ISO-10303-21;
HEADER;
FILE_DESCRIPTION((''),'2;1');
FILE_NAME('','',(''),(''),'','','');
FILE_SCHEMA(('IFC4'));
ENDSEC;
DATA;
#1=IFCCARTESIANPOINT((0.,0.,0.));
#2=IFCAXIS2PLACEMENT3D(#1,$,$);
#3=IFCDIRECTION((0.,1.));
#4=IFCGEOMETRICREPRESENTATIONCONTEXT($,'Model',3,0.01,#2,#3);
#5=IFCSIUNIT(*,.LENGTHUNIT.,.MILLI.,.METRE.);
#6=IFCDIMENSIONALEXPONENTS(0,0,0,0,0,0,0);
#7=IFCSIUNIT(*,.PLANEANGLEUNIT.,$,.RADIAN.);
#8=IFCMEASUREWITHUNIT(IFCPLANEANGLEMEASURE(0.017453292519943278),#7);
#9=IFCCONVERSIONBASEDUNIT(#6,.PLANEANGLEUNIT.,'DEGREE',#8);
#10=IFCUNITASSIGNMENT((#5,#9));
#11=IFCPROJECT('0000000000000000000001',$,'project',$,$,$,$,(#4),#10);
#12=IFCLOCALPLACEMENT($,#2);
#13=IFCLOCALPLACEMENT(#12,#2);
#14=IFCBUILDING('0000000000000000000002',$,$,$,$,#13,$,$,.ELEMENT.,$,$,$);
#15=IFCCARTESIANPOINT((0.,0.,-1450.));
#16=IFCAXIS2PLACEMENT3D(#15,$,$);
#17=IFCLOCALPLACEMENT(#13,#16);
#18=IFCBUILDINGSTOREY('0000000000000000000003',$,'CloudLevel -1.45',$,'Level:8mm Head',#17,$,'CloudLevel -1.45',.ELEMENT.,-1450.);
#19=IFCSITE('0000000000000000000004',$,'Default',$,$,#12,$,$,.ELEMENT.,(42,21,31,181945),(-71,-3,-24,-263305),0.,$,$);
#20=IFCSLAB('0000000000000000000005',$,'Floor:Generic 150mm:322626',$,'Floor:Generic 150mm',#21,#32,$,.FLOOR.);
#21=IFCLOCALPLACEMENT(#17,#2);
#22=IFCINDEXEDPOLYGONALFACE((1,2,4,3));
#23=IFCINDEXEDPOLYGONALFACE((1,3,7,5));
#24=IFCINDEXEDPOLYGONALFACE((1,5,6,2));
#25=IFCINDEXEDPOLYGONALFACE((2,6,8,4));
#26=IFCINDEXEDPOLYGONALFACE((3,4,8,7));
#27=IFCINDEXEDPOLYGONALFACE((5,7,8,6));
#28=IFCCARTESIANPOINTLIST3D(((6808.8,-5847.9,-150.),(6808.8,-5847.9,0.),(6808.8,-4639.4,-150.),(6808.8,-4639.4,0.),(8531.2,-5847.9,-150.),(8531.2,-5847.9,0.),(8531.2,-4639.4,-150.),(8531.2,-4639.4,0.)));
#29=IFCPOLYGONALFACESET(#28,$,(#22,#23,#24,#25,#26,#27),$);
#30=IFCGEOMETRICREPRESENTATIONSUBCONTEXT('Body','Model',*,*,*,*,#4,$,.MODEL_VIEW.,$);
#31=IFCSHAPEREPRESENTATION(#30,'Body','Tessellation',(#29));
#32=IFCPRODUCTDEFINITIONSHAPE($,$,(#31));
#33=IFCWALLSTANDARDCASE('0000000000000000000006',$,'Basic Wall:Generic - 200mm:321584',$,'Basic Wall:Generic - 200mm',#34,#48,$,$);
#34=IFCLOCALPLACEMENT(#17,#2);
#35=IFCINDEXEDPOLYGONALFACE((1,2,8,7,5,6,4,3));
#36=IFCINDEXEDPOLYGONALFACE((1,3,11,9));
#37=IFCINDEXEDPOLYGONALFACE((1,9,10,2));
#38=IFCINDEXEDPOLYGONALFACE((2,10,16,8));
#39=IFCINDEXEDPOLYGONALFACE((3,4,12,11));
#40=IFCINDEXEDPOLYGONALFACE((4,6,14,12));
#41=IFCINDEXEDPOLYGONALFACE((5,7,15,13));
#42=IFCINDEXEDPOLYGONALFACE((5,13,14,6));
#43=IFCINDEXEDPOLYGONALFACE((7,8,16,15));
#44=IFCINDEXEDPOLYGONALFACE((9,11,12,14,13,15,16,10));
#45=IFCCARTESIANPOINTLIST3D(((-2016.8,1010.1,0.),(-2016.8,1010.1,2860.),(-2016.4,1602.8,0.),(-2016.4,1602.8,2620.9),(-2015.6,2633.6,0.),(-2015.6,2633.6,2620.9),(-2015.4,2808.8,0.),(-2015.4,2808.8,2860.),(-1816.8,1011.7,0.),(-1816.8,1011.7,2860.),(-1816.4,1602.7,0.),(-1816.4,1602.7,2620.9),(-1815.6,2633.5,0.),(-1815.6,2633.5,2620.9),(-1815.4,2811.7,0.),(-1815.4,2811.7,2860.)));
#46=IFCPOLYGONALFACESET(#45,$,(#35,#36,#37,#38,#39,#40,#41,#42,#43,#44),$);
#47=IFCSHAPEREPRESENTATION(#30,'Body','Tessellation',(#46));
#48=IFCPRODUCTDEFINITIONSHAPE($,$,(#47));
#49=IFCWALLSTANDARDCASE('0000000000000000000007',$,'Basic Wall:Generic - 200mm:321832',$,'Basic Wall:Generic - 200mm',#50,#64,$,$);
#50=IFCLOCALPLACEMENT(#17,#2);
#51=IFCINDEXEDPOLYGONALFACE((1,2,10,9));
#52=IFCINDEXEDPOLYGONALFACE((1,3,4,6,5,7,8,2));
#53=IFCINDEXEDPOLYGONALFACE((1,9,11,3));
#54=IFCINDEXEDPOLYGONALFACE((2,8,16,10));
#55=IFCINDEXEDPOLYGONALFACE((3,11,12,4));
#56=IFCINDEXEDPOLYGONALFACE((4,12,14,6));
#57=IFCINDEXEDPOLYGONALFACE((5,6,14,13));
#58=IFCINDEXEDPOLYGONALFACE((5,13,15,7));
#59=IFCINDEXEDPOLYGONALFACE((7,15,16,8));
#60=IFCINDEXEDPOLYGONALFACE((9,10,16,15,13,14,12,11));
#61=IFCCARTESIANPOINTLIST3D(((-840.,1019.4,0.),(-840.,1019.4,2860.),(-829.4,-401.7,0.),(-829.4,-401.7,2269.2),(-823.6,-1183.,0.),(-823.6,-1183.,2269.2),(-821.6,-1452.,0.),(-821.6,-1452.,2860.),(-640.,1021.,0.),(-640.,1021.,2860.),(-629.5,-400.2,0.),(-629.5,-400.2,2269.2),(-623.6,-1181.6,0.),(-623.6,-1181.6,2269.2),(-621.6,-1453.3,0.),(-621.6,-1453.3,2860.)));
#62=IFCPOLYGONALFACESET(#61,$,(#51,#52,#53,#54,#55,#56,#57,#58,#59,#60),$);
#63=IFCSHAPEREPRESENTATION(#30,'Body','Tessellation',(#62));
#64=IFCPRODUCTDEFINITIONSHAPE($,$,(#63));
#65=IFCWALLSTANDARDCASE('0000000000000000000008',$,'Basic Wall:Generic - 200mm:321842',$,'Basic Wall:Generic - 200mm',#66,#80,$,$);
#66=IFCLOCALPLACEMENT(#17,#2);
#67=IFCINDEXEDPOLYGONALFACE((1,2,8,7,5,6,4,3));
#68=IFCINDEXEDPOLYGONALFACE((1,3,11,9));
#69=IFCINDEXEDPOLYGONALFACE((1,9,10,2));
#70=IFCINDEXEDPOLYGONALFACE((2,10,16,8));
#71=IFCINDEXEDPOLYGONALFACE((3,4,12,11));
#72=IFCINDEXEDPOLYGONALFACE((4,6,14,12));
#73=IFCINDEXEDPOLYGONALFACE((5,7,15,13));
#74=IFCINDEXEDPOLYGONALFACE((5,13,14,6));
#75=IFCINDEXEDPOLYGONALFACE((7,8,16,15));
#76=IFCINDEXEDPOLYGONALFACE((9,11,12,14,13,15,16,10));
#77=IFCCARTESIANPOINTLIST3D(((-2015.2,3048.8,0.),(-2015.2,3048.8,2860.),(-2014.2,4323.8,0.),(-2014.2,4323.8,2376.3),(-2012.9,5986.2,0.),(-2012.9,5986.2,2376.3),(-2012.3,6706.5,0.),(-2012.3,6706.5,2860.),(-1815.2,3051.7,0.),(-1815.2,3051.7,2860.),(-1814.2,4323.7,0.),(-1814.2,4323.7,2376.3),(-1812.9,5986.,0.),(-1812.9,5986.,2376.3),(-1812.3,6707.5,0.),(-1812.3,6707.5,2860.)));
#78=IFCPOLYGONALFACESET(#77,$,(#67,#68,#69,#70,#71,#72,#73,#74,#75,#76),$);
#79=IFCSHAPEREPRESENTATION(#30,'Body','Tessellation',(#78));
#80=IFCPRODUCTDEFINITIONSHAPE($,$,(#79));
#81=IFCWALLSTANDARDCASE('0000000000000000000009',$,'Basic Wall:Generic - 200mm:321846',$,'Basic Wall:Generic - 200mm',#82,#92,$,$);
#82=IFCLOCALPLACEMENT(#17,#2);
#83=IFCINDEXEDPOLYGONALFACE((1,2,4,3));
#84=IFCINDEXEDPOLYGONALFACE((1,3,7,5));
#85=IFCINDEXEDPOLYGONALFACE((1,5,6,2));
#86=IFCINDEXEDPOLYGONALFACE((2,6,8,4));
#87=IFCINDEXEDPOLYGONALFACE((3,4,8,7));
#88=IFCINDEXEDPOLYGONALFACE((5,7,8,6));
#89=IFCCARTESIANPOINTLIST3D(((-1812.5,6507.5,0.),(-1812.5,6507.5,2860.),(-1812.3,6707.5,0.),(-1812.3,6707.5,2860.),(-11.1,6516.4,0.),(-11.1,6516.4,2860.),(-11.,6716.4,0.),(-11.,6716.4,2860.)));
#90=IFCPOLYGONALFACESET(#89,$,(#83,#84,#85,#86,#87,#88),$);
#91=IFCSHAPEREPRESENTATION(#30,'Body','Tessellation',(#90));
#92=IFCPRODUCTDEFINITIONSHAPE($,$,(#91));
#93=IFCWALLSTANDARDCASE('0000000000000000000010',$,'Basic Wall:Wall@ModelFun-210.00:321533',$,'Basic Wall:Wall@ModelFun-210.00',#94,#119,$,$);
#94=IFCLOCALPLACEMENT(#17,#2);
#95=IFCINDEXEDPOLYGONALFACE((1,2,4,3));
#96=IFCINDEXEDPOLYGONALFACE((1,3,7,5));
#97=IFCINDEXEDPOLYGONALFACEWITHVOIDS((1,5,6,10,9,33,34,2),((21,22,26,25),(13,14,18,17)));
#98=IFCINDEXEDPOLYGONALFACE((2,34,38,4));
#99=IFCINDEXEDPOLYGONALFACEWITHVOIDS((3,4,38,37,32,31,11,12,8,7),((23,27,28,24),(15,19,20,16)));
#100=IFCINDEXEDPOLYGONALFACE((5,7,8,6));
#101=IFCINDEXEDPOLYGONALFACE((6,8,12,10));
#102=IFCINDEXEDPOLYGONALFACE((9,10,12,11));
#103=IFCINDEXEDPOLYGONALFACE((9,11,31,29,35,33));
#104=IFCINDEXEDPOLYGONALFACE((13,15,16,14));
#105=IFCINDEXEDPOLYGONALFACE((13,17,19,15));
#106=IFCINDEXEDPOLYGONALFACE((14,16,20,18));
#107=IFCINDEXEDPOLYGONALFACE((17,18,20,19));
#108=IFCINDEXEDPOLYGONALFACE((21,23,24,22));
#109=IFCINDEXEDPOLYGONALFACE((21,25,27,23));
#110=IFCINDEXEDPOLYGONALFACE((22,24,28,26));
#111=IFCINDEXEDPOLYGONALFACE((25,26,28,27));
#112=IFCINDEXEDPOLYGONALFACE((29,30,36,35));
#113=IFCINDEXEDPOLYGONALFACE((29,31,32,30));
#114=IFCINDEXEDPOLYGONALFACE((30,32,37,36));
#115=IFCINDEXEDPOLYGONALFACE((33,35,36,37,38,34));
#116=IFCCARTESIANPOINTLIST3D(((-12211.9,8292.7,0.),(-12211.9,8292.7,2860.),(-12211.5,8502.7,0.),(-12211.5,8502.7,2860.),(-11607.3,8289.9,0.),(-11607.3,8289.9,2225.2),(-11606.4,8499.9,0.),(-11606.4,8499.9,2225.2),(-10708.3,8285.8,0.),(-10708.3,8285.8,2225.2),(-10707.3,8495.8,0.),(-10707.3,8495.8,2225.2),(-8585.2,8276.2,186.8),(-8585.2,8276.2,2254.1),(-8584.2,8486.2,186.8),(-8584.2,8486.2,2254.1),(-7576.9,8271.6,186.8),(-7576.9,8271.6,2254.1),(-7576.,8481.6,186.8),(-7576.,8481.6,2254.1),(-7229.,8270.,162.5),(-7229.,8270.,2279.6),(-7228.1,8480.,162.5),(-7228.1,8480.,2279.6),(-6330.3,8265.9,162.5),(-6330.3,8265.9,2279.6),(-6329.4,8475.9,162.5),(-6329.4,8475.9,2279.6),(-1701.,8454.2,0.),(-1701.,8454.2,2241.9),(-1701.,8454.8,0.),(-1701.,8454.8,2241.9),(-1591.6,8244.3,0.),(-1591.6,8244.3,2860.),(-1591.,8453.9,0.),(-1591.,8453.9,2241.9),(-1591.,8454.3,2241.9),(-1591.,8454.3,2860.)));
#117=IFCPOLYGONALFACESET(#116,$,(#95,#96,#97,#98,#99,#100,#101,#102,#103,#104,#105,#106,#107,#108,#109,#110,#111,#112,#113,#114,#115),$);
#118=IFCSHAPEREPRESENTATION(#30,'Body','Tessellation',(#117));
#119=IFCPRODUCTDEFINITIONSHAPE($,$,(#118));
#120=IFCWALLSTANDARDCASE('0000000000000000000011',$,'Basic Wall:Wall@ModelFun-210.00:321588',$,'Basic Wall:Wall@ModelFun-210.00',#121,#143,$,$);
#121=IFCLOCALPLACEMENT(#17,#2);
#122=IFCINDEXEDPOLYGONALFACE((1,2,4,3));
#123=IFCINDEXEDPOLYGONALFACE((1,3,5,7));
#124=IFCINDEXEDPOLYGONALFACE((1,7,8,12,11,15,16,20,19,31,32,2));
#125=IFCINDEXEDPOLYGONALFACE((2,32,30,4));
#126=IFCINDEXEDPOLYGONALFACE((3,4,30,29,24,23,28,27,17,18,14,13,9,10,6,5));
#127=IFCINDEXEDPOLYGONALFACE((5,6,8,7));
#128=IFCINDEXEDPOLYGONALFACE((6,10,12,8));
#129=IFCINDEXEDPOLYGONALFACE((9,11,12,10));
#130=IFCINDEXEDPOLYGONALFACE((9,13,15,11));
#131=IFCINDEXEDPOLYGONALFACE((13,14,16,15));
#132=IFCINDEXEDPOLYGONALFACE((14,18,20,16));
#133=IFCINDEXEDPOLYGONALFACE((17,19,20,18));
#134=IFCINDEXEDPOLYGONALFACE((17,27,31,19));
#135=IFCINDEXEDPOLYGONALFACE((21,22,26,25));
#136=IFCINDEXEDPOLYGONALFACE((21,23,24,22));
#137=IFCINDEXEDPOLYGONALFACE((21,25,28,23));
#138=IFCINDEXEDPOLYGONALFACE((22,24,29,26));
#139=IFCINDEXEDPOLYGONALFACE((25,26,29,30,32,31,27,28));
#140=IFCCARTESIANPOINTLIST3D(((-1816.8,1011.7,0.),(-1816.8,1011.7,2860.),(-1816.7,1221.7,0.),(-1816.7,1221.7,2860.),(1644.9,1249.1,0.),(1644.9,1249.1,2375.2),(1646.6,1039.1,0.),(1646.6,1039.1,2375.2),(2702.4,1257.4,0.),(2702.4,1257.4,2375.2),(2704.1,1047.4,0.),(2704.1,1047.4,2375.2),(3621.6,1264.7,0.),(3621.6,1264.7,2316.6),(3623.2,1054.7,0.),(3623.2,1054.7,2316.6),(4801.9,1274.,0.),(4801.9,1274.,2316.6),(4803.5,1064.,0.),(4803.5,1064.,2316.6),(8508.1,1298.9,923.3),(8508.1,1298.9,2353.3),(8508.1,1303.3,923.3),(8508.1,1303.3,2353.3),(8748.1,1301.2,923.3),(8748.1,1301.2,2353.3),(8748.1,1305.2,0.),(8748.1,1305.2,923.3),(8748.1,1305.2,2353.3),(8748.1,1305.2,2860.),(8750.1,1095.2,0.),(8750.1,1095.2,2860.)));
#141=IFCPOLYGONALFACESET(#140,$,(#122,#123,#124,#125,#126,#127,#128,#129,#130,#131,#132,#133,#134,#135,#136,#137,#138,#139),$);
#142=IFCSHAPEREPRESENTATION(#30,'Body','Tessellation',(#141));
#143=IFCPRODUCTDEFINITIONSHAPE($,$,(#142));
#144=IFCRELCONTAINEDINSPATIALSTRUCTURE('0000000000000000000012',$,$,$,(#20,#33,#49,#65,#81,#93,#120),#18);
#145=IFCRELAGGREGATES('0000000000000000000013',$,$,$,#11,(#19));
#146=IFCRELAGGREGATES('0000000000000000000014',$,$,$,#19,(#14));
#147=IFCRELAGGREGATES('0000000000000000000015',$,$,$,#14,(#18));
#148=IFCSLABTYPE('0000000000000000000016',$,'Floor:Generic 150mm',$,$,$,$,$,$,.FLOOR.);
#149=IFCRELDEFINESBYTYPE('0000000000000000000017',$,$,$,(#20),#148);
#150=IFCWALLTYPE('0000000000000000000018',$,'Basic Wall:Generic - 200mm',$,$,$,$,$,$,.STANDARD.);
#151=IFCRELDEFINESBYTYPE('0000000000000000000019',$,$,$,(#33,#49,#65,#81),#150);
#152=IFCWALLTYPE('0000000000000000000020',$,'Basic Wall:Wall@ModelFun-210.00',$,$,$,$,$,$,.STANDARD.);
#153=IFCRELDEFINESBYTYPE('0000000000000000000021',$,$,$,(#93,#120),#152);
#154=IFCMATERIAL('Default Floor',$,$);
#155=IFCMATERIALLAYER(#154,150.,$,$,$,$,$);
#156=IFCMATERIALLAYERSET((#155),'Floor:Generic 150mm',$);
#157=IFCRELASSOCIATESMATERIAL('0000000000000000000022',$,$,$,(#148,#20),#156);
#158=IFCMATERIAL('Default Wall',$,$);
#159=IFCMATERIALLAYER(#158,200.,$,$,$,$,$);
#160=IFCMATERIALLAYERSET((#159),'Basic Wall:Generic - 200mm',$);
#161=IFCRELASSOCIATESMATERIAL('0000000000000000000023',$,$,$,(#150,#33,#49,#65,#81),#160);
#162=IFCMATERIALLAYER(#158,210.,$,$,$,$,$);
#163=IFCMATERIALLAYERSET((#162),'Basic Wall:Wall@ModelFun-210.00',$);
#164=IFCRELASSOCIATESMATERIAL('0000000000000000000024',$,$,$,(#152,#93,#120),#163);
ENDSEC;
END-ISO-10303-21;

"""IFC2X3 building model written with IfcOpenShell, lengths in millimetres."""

from ifc_helpers import new_model, entity, si_unit, converted_unit, direction, frame, frame_2d, origin, origin_2d_with_axis, place, context, subcontext, project, spatial, polyline, rectangle, outline, extrude, material, layer, layer_set, layer_usage, type_object, element, save


model = new_model("IFC2X3")

# Units and contexts
model_context = context("Model", 3, precision=0.01, world=origin(), true_north=direction((0.0, 1.0)))
body_context = subcontext(model_context, "Body", "Model", "MODEL_VIEW")
ifc_project = project(units=[si_unit("LENGTHUNIT", "METRE", prefix="MILLI"), converted_unit("PLANEANGLEUNIT", "DEGREE", entity("IfcPlaneAngleMeasure", 0.017453292519943278), si_unit("PLANEANGLEUNIT", "RADIAN"), dimensions=[0, 0, 0, 0, 0, 0, 0])], contexts=[model_context])

# Site, building, storey
site_placement = place(None, origin())
site = spatial("IfcSite", under=ifc_project, at=site_placement, Name="Default", CompositionType="ELEMENT", RefLatitude=(42, 21, 31, 181945), RefLongitude=(-71, -3, -24, -263305), RefElevation=0.0)
building_placement = place(site_placement, origin())
building = spatial("IfcBuilding", under=site, at=building_placement, CompositionType="ELEMENT")
storey_placement = place(building_placement, frame((0.0, 0.0, -1450.0)))
storey = spatial("IfcBuildingStorey", under=building, at=storey_placement, Name="CloudLevel -1.45", ObjectType="Level:8mm Head", LongName="CloudLevel -1.45", CompositionType="ELEMENT", Elevation=-1450.0)

# Slab
ifc_material_1 = material(Name="Default Floor")
ifc_layer_1 = layer(ifc_material_1, 150.0)
ifc_layer_set_1 = layer_set([ifc_layer_1], Name="Floor:Generic 150mm")
ifc_layer_usage_1 = layer_usage(ifc_layer_set_1, "AXIS3", "POSITIVE", 0.0)
slab_type = type_object("IfcSlabType", Name="Floor:Generic 150mm", PredefinedType="FLOOR", material=ifc_layer_set_1)
slab_1_placement = place(storey_placement, origin())
element("IfcSlab", 1, at=slab_1_placement, inside=storey, type_object=slab_type, material=ifc_layer_usage_1, Name="Floor:Generic 150mm:322626", ObjectType="Floor:Generic 150mm", PredefinedType="FLOOR", context=body_context, shape_type="SweptSolid", body=[
    extrude(rectangle(XDim=1208.4, YDim=1722.4, at=origin_2d_with_axis()), frame((7670.0, -5243.6, 0.0), z_axis=(0.0, 0.0, -1.0), x_axis=(0.0, 1.0, 0.0)), (0.0, 0.0, 1.0), 150.0),
])

# Walls, openings
ifc_material_2 = material(Name="Default Wall")
ifc_layer_2 = layer(ifc_material_2, 200.0)
ifc_layer_set_2 = layer_set([ifc_layer_2], Name="Basic Wall:Generic - 200mm")
ifc_layer_usage_2 = layer_usage(ifc_layer_set_2, "AXIS2", "NEGATIVE", 100.0)
wall_type_1 = type_object("IfcWallType", Name="Basic Wall:Generic - 200mm", PredefinedType="STANDARD", material=ifc_layer_set_2)
wall_1_placement = place(storey_placement, frame((-1916.8, 1010.0, 0.0), z_axis=(0.0, 0.0, 1.0), x_axis=(0.000789, 1.0, 0.0)))
wall_1 = element("IfcWallStandardCase", 2, at=wall_1_placement, inside=storey, type_object=wall_type_1, material=ifc_layer_usage_2, Name="Basic Wall:Generic - 200mm:321584", ObjectType="Basic Wall:Generic - 200mm", context=body_context, shape_type="SweptSolid", body=[
    extrude(outline(polyline([(1.7, -100.0), (211.7, -100.0), (1801.7, -100.0), (1798.7, 100.0), (159.3, 100.0), (0.0, 100.0), (1.6, -81.1), (1.7, -100.0)])), origin(), (0.0, 0.0, 1.0), 2860.0),
])
opening_1_placement = place(wall_1_placement, frame((592.7, -100.0, 0.0)))
element("IfcOpeningElement", 3, at=opening_1_placement, cuts=wall_1, ObjectType="Opening", context=body_context, shape_type="SweptSolid", body=[
    extrude(rectangle(XDim=1030.8, YDim=2620.9, at=frame_2d((1310.5, 515.4), x_axis=(0.0, 1.0))), frame((0.0, 0.0, 0.0), z_axis=(0.0, 1.0, 0.0), x_axis=(0.0, 0.0, 1.0)), (0.0, 0.0, 1.0), 200.0),
])
wall_2_placement = place(storey_placement, frame((-740.0, 1020.2, 0.0), z_axis=(0.0, 0.0, 1.0), x_axis=(0.007442, -0.999972, 0.0)))
wall_2 = element("IfcWallStandardCase", 4, at=wall_2_placement, inside=storey, type_object=wall_type_1, material=ifc_layer_usage_2, Name="Basic Wall:Generic - 200mm:321832", ObjectType="Basic Wall:Generic - 200mm", context=body_context, shape_type="SweptSolid", body=[
    extrude(outline(polyline([(0.1, -100.0), (2471.6, -100.0), (2474.3, 100.0), (0.0, 100.0), (0.1, -100.0)])), origin(), (0.0, 0.0, 1.0), 2860.0),
])
opening_2_placement = place(wall_2_placement, frame((1421.2, -100.0, 0.0)))
element("IfcOpeningElement", 5, at=opening_2_placement, cuts=wall_2, ObjectType="Opening", context=body_context, shape_type="SweptSolid", body=[
    extrude(rectangle(XDim=781.4, YDim=2269.2, at=frame_2d((1134.6, 390.7), x_axis=(0.0, 1.0))), frame((0.0, 0.0, 0.0), z_axis=(0.0, 1.0, 0.0), x_axis=(0.0, 0.0, 1.0)), (0.0, 0.0, 1.0), 200.0),
])
wall_3_placement = place(storey_placement, frame((-1912.3, 6707.5, 0.0), z_axis=(0.0, 0.0, 1.0), x_axis=(-0.000789, -1.0, 0.0)))
wall_3 = element("IfcWallStandardCase", 6, at=wall_3_placement, inside=storey, type_object=wall_type_1, material=ifc_layer_usage_2, Name="Basic Wall:Generic - 200mm:321842", ObjectType="Basic Wall:Generic - 200mm", context=body_context, shape_type="SweptSolid", body=[
    extrude(outline(polyline([(1.2, -100.0), (2995.4, -100.0), (3335.4, -100.0), (3658.8, -100.0), (3655.7, 100.0), (200.0, 100.0), (0.0, 100.0), (1.2, -100.0)])), origin(), (0.0, 0.0, 1.0), 2860.0),
])
opening_3_placement = place(wall_3_placement, frame((721.4, -100.0, 0.0)))
element("IfcOpeningElement", 7, at=opening_3_placement, cuts=wall_3, ObjectType="Opening", context=body_context, shape_type="SweptSolid", body=[
    extrude(rectangle(XDim=1662.3, YDim=2376.3, at=frame_2d((1188.1, 831.2), x_axis=(0.0, 1.0))), frame((0.0, 0.0, 0.0), z_axis=(0.0, 1.0, 0.0), x_axis=(0.0, 0.0, 1.0)), (0.0, 0.0, 1.0), 200.0),
])

# Wall
wall_4_placement = place(storey_placement, frame((-10.5, 6616.4, 0.0), z_axis=(0.0, 0.0, 1.0), x_axis=(-0.999988, -0.004967, 0.0)))
element("IfcWallStandardCase", 8, at=wall_4_placement, inside=storey, type_object=wall_type_1, material=ifc_layer_usage_2, Name="Basic Wall:Generic - 200mm:321846", ObjectType="Basic Wall:Generic - 200mm", context=body_context, shape_type="SweptSolid", body=[
    extrude(outline(polyline([(1801.3, -100.0), (1802.5, 100.0), (1.0, 100.0), (0.0, -100.0), (1801.3, -100.0)])), origin(), (0.0, 0.0, 1.0), 2860.0),
])

# Walls, openings
ifc_layer_3 = layer(ifc_material_2, 210.0)
ifc_layer_set_3 = layer_set([ifc_layer_3], Name="Basic Wall:Wall@ModelFun-210.00")
ifc_layer_usage_3 = layer_usage(ifc_layer_set_3, "AXIS2", "NEGATIVE", 105.0)
wall_type_2 = type_object("IfcWallType", Name="Basic Wall:Wall@ModelFun-210.00", PredefinedType="STANDARD", material=ifc_layer_set_3)
wall_5_placement = place(storey_placement, frame((-1591.1, 8349.3, 0.0), z_axis=(0.0, 0.0, 1.0), x_axis=(-0.99999, 0.004552, 0.0)))
wall_5 = element("IfcWallStandardCase", 9, at=wall_5_placement, inside=storey, type_object=wall_type_2, material=ifc_layer_usage_3, Name="Basic Wall:Wall@ModelFun-210.00:321533", ObjectType="Basic Wall:Wall@ModelFun-210.00", context=body_context, shape_type="SweptSolid", body=[
    extrude(outline(polyline([(0.3, -105.0), (110.3, -105.0), (2714.6, -105.0), (2914.6, -105.0), (5712.3, -105.0), (5922.3, -105.0), (10621.0, -105.0), (10620.4, 105.0), (7415.2, 105.0), (7215.2, 105.0), (42.9, 105.0), (0.0, 105.0), (0.2, -3.9), (0.3, -105.0)])), origin(), (0.0, 0.0, 1.0), 2860.0),
])
opening_4_placement = place(wall_5_placement, origin())
element("IfcOpeningElement", 10, at=opening_4_placement, cuts=wall_5, ObjectType="Opening", context=body_context, shape_type="SweptSolid", body=[
    extrude(rectangle(XDim=2241.9, YDim=110.0, at=frame_2d((0.0, 0.0), x_axis=(0.0, 1.0))), frame((56.8, -1102.6, 1121.0), z_axis=(-0.00152, 0.999999, 0.0), x_axis=(-0.999999, -0.00152, 0.0)), (0.0, 0.0, 1.0), 998.2),
])
opening_5_placement = place(wall_5_placement, frame((9116.8, -105.0, 0.0)))
element("IfcOpeningElement", 11, at=opening_5_placement, cuts=wall_5, ObjectType="Opening", context=body_context, shape_type="SweptSolid", body=[
    extrude(rectangle(XDim=899.1, YDim=2225.2, at=frame_2d((1112.6, 449.5), x_axis=(0.0, 1.0))), frame((0.0, 0.0, 0.0), z_axis=(0.0, 1.0, 0.0), x_axis=(0.0, 0.0, 1.0)), (0.0, 0.0, 1.0), 210.0),
])
opening_6_placement = place(wall_5_placement, frame((5985.4, -105.0, 186.8)))
element("IfcOpeningElement", 12, at=opening_6_placement, cuts=wall_5, ObjectType="Opening", context=body_context, shape_type="SweptSolid", body=[
    extrude(rectangle(XDim=1008.3, YDim=2067.2, at=frame_2d((1033.6, 504.1), x_axis=(0.0, 1.0))), frame((0.0, 0.0, 0.0), z_axis=(0.0, 1.0, 0.0), x_axis=(0.0, 0.0, 1.0)), (0.0, 0.0, 1.0), 210.0),
])
opening_7_placement = place(wall_5_placement, frame((4738.8, -105.0, 162.5)))
element("IfcOpeningElement", 13, at=opening_7_placement, cuts=wall_5, ObjectType="Opening", context=body_context, shape_type="SweptSolid", body=[
    extrude(rectangle(XDim=898.7, YDim=2117.2, at=frame_2d((1058.6, 449.3), x_axis=(0.0, 1.0))), frame((0.0, 0.0, 0.0), z_axis=(0.0, 1.0, 0.0), x_axis=(0.0, 0.0, 1.0)), (0.0, 0.0, 1.0), 210.0),
])
wall_6_placement = place(storey_placement, frame((-1817.7, 1116.7, 0.0), z_axis=(0.0, 0.0, 1.0), x_axis=(0.999969, 0.007904, 0.0)))
wall_6 = element("IfcWallStandardCase", 14, at=wall_6_placement, inside=storey, type_object=wall_type_2, material=ifc_layer_usage_3, Name="Basic Wall:Wall@ModelFun-210.00:321588", ObjectType="Basic Wall:Wall@ModelFun-210.00", context=body_context, shape_type="SweptSolid", body=[
    extrude(outline(polyline([(0.0, -105.0), (976.8, -105.0), (1176.8, -105.0), (3237.3, -105.0), (3417.3, -105.0), (4936.9, -105.0), (5146.9, -105.0), (6719.8, -105.0), (6959.8, -105.0), (8889.3, -105.0), (9099.3, -105.0), (10088.5, -105.0), (10328.5, -105.0), (10567.3, -105.0), (10566.9, 105.0), (10326.9, 105.0), (2047.3, 105.0), (1807.3, 105.0), (1.8, 105.0), (0.0, -105.0)])), origin(), (0.0, 0.0, 1.0), 2860.0),
])
opening_8_placement = place(wall_6_placement, origin())
element("IfcOpeningElement", 15, at=opening_8_placement, cuts=wall_6, ObjectType="Opening", context=body_context, shape_type="SweptSolid", body=[
    extrude(rectangle(XDim=1430.0, YDim=240.0, at=frame_2d((0.0, 0.0), x_axis=(0.0, 1.0))), frame((10446.9, 100.8, 1638.3), z_axis=(-0.001607, 0.999999, 0.0), x_axis=(-0.999999, -0.001607, 0.0)), (0.0, 0.0, 1.0), 510.0),
])
opening_9_placement = place(wall_6_placement, frame((5440.2, -105.0, 0.0)))
element("IfcOpeningElement", 16, at=opening_9_placement, cuts=wall_6, ObjectType="Opening", context=body_context, shape_type="SweptSolid", body=[
    extrude(rectangle(XDim=1180.4, YDim=2316.6, at=frame_2d((1158.3, 590.2), x_axis=(0.0, 1.0))), frame((0.0, 0.0, 0.0), z_axis=(0.0, 1.0, 0.0), x_axis=(0.0, 0.0, 1.0)), (0.0, 0.0, 1.0), 210.0),
])
opening_10_placement = place(wall_6_placement, frame((3463.5, -105.0, 0.0)))
element("IfcOpeningElement", 17, at=opening_10_placement, cuts=wall_6, ObjectType="Opening", context=body_context, shape_type="SweptSolid", body=[
    extrude(rectangle(XDim=1057.5, YDim=2375.2, at=frame_2d((1187.6, 528.8), x_axis=(0.0, 1.0))), frame((0.0, 0.0, 0.0), z_axis=(0.0, 1.0, 0.0), x_axis=(0.0, 0.0, 1.0)), (0.0, 0.0, 1.0), 210.0),
])

save(model, "model.ifc")
